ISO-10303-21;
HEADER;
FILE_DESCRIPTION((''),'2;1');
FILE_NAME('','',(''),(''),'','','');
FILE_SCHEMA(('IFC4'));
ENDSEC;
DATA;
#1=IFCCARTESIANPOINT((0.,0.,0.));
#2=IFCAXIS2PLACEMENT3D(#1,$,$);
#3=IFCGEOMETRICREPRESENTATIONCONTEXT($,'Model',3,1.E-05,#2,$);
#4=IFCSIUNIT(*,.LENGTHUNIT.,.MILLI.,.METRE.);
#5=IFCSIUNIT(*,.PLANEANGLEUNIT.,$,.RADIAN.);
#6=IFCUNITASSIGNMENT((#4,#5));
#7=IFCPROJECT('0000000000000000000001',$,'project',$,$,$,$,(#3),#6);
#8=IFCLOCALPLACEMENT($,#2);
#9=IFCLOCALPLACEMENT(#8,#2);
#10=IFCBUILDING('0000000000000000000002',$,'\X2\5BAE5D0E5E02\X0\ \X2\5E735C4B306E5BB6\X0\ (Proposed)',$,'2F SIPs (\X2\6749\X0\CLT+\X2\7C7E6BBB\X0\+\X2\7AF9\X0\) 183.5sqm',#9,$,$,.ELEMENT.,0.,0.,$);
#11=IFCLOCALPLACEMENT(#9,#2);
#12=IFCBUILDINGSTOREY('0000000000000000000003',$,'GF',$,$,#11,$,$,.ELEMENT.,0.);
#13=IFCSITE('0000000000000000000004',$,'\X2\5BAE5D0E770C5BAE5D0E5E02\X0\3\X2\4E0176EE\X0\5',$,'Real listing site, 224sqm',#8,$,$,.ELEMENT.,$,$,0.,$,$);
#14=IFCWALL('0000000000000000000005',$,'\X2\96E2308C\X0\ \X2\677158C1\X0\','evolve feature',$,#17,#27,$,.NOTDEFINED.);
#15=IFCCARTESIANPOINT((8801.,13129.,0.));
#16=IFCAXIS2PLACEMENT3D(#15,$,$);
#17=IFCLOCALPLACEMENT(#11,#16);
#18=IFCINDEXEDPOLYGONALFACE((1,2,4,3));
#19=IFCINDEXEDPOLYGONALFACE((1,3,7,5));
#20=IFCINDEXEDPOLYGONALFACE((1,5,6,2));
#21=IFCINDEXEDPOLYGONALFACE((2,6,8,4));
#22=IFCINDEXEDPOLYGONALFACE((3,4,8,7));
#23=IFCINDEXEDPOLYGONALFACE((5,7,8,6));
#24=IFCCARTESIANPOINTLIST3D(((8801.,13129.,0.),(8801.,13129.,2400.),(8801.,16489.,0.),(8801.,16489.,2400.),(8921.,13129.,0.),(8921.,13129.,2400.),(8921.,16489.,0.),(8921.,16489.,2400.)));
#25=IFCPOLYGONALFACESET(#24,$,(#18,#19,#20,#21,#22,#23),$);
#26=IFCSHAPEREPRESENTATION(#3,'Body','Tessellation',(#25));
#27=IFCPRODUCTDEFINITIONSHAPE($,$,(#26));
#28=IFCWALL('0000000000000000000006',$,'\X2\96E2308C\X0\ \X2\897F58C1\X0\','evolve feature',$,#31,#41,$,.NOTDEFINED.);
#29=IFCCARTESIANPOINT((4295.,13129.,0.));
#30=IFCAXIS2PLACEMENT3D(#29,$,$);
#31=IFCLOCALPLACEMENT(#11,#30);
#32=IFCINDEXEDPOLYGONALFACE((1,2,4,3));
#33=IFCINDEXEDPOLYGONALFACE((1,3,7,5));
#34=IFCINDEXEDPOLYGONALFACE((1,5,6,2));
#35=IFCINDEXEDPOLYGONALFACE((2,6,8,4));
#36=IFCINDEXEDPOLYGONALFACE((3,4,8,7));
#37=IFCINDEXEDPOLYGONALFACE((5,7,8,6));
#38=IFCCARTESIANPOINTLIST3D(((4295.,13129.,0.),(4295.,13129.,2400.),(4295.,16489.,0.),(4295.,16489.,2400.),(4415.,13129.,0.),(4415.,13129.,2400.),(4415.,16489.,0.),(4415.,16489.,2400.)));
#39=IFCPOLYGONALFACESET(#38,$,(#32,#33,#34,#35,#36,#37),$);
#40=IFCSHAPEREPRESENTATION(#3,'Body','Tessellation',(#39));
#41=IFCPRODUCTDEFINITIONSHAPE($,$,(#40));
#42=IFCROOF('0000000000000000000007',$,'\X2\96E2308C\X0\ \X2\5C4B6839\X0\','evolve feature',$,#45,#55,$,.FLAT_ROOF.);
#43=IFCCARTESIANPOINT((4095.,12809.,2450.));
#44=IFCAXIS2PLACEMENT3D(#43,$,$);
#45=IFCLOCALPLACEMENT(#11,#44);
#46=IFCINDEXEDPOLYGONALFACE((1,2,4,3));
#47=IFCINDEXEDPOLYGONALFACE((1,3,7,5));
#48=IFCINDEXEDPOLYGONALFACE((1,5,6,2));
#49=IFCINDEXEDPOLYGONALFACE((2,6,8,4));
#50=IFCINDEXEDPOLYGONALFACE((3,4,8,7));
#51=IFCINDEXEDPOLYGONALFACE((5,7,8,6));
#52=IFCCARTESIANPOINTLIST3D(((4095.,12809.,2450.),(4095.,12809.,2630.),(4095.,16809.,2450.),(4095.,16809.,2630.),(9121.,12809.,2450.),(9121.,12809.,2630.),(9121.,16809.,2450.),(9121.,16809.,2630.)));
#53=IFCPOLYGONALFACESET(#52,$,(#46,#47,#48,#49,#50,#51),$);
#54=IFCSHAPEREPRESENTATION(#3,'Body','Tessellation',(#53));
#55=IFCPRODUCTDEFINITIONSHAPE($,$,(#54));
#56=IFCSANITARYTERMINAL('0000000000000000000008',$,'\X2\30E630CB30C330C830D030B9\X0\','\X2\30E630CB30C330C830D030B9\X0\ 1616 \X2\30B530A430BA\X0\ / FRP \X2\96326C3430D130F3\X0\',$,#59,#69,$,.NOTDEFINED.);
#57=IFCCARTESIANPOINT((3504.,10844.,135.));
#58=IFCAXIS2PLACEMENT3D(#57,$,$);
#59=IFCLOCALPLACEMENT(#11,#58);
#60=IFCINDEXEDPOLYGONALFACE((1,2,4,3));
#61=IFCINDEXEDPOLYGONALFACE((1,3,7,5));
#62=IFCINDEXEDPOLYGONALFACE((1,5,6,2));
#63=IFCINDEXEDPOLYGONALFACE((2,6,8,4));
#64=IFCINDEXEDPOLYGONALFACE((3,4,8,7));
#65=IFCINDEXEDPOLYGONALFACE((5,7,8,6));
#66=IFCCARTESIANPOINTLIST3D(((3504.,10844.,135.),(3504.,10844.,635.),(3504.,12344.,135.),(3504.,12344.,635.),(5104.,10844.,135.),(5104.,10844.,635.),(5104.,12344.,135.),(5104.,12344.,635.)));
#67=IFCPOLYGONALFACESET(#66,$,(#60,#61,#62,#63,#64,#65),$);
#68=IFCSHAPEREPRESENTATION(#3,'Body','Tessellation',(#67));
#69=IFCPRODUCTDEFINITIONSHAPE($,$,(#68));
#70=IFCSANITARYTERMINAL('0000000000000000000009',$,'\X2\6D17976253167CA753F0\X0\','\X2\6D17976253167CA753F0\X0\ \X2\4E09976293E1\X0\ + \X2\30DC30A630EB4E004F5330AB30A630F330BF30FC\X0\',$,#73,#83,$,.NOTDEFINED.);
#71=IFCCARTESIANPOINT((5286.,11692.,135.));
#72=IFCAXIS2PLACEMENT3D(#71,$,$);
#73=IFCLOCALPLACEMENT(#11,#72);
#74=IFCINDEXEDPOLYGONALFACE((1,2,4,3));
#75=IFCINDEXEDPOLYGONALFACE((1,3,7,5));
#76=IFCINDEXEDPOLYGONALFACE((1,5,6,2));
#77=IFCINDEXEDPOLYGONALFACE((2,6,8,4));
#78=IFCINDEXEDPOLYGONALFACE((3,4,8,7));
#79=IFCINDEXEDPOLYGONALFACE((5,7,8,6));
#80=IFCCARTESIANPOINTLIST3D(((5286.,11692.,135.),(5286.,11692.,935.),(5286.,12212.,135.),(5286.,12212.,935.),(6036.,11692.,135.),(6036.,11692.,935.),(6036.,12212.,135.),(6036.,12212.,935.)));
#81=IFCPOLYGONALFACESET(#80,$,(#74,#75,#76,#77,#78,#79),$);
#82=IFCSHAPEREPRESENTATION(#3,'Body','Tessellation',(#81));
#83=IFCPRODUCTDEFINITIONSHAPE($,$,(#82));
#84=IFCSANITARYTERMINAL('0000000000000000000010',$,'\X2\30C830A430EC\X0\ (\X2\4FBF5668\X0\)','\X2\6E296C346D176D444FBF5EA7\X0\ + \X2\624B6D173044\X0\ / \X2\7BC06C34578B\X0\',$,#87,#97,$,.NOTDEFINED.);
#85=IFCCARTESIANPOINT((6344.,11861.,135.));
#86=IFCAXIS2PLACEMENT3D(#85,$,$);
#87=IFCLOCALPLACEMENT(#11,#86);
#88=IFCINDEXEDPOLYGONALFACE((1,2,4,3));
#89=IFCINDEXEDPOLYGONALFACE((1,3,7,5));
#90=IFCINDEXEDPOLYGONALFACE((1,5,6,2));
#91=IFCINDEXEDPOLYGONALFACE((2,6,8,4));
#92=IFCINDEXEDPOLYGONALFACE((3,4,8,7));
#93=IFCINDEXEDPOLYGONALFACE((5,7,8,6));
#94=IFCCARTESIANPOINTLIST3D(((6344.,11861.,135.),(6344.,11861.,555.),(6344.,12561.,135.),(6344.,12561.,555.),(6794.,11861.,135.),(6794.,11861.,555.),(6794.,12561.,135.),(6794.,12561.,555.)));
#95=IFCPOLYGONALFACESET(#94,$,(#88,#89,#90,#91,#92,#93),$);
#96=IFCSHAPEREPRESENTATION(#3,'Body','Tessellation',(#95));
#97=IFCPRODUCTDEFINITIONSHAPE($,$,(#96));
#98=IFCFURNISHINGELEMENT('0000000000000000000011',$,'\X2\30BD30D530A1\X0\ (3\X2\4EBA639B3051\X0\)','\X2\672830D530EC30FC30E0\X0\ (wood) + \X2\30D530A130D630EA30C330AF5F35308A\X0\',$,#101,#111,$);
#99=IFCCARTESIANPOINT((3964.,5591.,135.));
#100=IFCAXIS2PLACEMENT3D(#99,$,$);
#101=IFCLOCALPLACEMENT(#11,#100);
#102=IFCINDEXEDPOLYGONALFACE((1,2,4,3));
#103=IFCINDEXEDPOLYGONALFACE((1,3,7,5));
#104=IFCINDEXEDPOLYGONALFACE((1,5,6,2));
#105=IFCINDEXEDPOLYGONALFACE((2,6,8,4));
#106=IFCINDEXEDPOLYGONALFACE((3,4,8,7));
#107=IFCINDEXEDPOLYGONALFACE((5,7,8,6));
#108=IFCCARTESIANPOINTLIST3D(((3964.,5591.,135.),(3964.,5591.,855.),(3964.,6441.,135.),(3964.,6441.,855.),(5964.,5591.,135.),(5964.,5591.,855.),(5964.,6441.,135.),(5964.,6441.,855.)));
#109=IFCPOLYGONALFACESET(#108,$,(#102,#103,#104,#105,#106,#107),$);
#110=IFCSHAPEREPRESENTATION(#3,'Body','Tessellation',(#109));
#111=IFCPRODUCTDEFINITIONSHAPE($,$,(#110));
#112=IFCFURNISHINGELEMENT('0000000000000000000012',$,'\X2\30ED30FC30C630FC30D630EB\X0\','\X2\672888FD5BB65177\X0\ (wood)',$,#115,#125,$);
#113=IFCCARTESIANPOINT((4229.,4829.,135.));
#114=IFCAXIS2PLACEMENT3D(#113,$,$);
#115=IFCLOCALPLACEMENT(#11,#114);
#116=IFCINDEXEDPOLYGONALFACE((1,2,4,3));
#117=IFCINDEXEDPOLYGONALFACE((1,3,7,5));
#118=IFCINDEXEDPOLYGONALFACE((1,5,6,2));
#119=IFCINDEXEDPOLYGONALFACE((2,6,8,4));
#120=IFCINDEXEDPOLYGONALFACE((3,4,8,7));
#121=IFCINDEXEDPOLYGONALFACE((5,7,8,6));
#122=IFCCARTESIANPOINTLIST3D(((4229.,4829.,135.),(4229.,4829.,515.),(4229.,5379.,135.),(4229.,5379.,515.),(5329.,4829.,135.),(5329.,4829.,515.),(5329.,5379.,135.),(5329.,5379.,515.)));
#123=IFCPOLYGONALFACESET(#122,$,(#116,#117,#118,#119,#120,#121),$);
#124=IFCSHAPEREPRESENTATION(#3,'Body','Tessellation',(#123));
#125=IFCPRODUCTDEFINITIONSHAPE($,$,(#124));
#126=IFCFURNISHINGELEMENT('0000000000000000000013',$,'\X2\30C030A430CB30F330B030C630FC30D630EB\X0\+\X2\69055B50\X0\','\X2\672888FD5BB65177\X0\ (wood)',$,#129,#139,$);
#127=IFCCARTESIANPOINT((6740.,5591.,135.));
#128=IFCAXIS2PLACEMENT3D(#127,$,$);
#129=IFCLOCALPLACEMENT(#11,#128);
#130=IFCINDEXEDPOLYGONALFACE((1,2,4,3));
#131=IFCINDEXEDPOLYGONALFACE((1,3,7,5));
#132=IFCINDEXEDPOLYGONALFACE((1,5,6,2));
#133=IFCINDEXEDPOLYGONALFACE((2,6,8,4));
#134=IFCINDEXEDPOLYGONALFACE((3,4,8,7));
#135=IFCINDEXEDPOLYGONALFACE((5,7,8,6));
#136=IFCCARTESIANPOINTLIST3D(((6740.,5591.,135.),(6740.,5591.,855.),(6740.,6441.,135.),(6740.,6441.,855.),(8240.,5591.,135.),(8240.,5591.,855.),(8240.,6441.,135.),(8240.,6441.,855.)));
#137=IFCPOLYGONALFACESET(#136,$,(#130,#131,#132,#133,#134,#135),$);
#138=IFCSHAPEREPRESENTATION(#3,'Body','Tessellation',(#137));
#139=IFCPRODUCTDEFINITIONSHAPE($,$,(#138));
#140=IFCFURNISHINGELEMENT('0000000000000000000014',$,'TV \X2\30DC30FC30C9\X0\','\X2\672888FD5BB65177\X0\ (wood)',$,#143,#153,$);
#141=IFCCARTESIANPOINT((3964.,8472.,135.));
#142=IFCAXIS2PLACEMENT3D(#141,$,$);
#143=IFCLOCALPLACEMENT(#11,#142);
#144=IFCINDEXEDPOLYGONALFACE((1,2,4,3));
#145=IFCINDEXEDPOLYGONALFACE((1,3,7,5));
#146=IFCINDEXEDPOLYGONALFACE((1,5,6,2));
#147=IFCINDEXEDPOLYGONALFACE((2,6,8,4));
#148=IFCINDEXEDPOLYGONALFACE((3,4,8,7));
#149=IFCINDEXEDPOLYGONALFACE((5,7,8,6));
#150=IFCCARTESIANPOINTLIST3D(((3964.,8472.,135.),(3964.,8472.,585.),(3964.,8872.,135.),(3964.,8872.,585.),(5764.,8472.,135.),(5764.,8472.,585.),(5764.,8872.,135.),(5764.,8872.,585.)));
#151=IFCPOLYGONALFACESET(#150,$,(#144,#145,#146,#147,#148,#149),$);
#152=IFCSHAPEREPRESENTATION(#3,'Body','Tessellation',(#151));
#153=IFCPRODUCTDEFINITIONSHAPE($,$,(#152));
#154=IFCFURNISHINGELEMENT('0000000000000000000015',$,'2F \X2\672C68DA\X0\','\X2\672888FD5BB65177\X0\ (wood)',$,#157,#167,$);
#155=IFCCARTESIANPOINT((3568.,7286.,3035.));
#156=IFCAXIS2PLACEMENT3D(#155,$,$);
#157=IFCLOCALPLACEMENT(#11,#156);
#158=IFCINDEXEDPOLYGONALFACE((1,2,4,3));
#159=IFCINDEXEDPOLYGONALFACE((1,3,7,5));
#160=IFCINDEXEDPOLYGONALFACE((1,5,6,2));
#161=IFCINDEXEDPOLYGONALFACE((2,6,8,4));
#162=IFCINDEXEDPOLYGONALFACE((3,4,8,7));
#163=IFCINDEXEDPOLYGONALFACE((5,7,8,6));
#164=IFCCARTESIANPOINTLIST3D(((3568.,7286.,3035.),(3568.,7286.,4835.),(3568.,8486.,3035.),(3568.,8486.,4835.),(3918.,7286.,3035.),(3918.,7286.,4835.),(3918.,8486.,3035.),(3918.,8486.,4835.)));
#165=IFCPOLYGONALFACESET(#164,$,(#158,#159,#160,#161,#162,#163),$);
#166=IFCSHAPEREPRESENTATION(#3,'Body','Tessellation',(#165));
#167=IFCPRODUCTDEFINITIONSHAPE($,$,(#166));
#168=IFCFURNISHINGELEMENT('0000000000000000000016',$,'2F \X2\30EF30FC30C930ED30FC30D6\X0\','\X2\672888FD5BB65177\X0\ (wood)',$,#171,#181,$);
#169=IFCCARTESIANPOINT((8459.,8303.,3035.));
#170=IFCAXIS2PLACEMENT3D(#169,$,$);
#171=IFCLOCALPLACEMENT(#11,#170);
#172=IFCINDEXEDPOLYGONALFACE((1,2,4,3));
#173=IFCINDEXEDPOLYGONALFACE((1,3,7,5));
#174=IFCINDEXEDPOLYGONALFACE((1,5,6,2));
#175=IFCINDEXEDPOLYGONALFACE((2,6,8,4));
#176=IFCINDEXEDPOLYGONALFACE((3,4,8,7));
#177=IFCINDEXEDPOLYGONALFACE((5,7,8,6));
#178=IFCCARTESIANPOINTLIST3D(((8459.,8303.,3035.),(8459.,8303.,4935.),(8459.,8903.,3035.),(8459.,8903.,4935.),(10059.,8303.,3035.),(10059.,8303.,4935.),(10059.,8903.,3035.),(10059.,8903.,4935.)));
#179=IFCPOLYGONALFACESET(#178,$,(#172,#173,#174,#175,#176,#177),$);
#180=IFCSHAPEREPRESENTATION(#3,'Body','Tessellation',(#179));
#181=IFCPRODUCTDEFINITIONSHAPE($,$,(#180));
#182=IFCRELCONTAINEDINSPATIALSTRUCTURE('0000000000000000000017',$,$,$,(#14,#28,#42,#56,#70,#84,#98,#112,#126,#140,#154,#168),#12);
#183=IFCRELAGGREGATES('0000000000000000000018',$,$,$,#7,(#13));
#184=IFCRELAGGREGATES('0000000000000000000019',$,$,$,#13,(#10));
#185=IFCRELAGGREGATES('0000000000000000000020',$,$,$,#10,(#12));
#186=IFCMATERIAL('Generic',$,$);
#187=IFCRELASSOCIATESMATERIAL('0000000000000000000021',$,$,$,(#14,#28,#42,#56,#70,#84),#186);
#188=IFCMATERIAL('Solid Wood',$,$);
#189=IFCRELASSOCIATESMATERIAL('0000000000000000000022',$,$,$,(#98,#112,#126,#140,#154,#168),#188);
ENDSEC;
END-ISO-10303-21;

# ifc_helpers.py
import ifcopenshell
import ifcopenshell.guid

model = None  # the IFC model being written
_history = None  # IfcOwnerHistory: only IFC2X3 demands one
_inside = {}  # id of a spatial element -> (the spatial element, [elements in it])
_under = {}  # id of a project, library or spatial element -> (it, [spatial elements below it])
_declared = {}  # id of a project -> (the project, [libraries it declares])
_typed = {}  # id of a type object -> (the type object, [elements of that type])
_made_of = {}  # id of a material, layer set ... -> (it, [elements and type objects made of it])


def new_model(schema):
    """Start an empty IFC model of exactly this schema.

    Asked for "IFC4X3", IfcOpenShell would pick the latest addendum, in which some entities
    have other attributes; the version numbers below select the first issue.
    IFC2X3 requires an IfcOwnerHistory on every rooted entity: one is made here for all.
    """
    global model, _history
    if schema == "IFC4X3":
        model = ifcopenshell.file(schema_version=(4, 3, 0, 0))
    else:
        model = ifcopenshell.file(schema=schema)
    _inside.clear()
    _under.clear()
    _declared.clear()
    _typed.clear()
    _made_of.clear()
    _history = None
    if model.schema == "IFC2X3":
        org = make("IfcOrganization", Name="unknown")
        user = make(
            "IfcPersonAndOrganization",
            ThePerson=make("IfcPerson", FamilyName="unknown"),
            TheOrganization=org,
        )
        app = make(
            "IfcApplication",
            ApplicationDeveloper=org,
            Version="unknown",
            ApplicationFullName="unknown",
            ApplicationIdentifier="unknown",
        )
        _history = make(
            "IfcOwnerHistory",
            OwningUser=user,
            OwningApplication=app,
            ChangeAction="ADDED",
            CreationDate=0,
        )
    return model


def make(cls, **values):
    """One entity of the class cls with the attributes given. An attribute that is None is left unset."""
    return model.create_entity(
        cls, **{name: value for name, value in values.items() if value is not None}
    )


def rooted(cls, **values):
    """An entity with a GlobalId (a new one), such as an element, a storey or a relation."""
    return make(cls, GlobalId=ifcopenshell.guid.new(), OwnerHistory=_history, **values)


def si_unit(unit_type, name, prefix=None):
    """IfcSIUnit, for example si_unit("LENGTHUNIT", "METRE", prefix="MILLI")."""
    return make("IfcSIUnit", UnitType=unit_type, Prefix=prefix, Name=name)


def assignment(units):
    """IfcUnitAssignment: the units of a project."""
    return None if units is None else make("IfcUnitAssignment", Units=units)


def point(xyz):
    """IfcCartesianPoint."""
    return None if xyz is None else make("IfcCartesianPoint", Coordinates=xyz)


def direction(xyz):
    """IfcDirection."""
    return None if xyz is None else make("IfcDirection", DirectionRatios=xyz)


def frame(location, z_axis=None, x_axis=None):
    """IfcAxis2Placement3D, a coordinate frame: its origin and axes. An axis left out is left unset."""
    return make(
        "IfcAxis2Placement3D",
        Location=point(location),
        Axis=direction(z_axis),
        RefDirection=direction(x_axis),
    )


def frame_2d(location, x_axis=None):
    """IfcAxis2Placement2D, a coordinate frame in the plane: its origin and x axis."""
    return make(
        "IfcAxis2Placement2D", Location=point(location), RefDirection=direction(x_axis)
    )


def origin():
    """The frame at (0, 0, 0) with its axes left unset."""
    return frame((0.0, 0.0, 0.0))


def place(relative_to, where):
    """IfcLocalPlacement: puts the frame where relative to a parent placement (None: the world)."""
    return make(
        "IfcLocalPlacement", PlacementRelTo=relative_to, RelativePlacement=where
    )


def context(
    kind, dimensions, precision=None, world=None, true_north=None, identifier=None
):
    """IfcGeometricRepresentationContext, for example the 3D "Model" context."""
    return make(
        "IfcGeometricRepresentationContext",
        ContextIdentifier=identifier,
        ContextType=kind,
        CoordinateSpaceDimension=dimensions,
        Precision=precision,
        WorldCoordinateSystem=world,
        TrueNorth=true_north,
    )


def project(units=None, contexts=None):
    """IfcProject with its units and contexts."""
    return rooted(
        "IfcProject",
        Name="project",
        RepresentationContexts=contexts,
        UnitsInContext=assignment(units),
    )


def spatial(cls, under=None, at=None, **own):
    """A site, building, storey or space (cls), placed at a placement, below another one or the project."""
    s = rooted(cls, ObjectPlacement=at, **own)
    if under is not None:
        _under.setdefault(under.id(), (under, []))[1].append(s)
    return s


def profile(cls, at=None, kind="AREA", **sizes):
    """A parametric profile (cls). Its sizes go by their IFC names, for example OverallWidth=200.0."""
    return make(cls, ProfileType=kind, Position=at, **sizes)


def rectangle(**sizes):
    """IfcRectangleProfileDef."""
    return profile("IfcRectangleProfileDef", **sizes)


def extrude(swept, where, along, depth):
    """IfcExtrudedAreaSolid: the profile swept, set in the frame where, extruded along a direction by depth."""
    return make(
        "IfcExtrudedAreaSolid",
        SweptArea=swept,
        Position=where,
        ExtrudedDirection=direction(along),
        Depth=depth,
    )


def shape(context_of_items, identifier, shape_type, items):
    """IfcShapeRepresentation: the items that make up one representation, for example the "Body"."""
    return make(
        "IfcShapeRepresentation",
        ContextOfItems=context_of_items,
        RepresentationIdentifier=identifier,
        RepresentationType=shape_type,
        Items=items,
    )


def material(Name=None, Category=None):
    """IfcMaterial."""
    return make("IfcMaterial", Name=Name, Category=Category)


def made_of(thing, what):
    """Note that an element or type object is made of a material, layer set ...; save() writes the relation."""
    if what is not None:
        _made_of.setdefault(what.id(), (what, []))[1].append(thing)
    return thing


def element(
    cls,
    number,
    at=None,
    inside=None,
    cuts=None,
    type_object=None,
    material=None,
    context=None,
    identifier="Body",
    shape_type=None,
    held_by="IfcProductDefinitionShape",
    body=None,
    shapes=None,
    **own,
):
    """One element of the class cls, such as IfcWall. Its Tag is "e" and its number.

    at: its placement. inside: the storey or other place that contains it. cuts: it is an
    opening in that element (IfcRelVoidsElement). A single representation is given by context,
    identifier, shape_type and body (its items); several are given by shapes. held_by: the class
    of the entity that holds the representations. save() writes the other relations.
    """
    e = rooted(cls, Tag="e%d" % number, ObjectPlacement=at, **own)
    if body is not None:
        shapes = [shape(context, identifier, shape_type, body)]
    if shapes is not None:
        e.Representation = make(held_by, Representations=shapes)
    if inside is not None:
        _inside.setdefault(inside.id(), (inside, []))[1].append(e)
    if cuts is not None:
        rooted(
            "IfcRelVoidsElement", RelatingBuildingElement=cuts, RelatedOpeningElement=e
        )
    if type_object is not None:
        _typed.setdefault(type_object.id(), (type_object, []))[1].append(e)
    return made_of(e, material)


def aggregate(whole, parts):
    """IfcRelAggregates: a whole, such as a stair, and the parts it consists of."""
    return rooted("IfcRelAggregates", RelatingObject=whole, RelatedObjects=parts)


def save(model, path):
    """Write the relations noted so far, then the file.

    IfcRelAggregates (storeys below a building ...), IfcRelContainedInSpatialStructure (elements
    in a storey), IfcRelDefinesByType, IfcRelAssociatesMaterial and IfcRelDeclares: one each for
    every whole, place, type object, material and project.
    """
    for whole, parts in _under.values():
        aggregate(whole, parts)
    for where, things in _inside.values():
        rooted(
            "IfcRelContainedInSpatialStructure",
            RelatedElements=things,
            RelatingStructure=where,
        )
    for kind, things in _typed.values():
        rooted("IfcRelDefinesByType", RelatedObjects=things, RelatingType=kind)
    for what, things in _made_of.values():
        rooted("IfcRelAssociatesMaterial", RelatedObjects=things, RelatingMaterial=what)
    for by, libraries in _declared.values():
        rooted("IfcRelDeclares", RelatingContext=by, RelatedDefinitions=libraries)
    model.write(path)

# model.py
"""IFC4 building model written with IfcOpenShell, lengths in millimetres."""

from ifc_helpers import new_model, si_unit, frame, frame_2d, origin, place, context, project, spatial, rectangle, extrude, material, element, save


model = new_model("IFC4")

# Units and contexts
model_context = context("Model", 3, precision=1e-05, world=origin())
ifc_project = project(units=[si_unit("LENGTHUNIT", "METRE", prefix="MILLI"), si_unit("PLANEANGLEUNIT", "RADIAN")], contexts=[model_context])

# Site, building, storey
site_placement = place(None, origin())
site = spatial("IfcSite", under=ifc_project, at=site_placement, Name="宮崎県宮崎市3丁目5", ObjectType="Real listing site, 224sqm", CompositionType="ELEMENT", RefElevation=0.0)
building_placement = place(site_placement, origin())
building = spatial("IfcBuilding", under=site, at=building_placement, Name="宮崎市 平屋の家 (Proposed)", ObjectType="2F SIPs (杉CLT+籾殻+竹) 183.5sqm", CompositionType="ELEMENT", ElevationOfRefHeight=0.0, ElevationOfTerrain=0.0)
storey_placement = place(building_placement, origin())
storey = spatial("IfcBuildingStorey", under=building, at=storey_placement, Name="GF", CompositionType="ELEMENT", Elevation=0.0)

# Shared definitions
ifc_material_1 = material(Name="Generic")

# Shared definitions
ifc_material_2 = material(Name="Solid Wood")

# Walls
wall_1_placement = place(storey_placement, frame((8801.0, 13129.0, 0.0)))
element("IfcWall", 1, at=wall_1_placement, inside=storey, material=ifc_material_1, Name="離れ 東壁", Description="evolve feature", PredefinedType="NOTDEFINED", context=model_context, shape_type="SweptSolid", body=[
    extrude(rectangle(XDim=120.0, YDim=3360.0, at=frame_2d((60.0, 1680.0))), frame((8801.0, 13129.0, 0.0)), (0.0, 0.0, 1.0), 2400.0),
])
wall_2_placement = place(storey_placement, frame((4295.0, 13129.0, 0.0)))
element("IfcWall", 2, at=wall_2_placement, inside=storey, material=ifc_material_1, Name="離れ 西壁", Description="evolve feature", PredefinedType="NOTDEFINED", context=model_context, shape_type="SweptSolid", body=[
    extrude(rectangle(XDim=120.0, YDim=3360.0, at=frame_2d((60.0, 1680.0))), frame((4295.0, 13129.0, 0.0)), (0.0, 0.0, 1.0), 2400.0),
])

# Roof
roof_1_placement = place(storey_placement, frame((4095.0, 12809.0, 2450.0)))
element("IfcRoof", 3, at=roof_1_placement, inside=storey, material=ifc_material_1, Name="離れ 屋根", Description="evolve feature", PredefinedType="FLAT_ROOF", context=model_context, shape_type="SweptSolid", body=[
    extrude(rectangle(XDim=5026.0, YDim=4000.0, at=frame_2d((2513.0, 2000.0))), frame((4095.0, 12809.0, 2450.0)), (0.0, 0.0, 1.0), 180.0),
])

# Sanitary terminals
sanitary_terminal_1_placement = place(storey_placement, frame((3504.0, 10844.0, 135.0)))
element("IfcSanitaryTerminal", 4, at=sanitary_terminal_1_placement, inside=storey, material=ifc_material_1, Name="ユニットバス", Description="ユニットバス 1616 サイズ / FRP 防水パン", PredefinedType="NOTDEFINED", context=model_context, shape_type="SweptSolid", body=[
    extrude(rectangle(XDim=1600.0, YDim=1500.0, at=frame_2d((800.0, 750.0))), frame((3504.0, 10844.0, 135.0)), (0.0, 0.0, 1.0), 500.0),
])
sanitary_terminal_2_placement = place(storey_placement, frame((5286.0, 11692.0, 135.0)))
element("IfcSanitaryTerminal", 5, at=sanitary_terminal_2_placement, inside=storey, material=ifc_material_1, Name="洗面化粧台", Description="洗面化粧台 三面鏡 + ボウル一体カウンター", PredefinedType="NOTDEFINED", context=model_context, shape_type="SweptSolid", body=[
    extrude(rectangle(XDim=750.0, YDim=520.0, at=frame_2d((375.0, 260.0))), frame((5286.0, 11692.0, 135.0)), (0.0, 0.0, 1.0), 800.0),
])
sanitary_terminal_3_placement = place(storey_placement, frame((6344.0, 11861.0, 135.0)))
element("IfcSanitaryTerminal", 6, at=sanitary_terminal_3_placement, inside=storey, material=ifc_material_1, Name="トイレ (便器)", Description="温水洗浄便座 + 手洗い / 節水型", PredefinedType="NOTDEFINED", context=model_context, shape_type="SweptSolid", body=[
    extrude(rectangle(XDim=450.0, YDim=700.0, at=frame_2d((225.0, 350.0))), frame((6344.0, 11861.0, 135.0)), (0.0, 0.0, 1.0), 420.0),
])

# Furnishing elements
furnishing_1_placement = place(storey_placement, frame((3964.0, 5591.0, 135.0)))
element("IfcFurnishingElement", 7, at=furnishing_1_placement, inside=storey, material=ifc_material_2, Name="ソファ (3人掛け)", Description="木フレーム (wood) + ファブリック張り", context=model_context, shape_type="SweptSolid", body=[
    extrude(rectangle(XDim=2000.0, YDim=850.0, at=frame_2d((1000.0, 425.0))), frame((3964.0, 5591.0, 135.0)), (0.0, 0.0, 1.0), 720.0),
])
furnishing_2_placement = place(storey_placement, frame((4229.0, 4829.0, 135.0)))
element("IfcFurnishingElement", 8, at=furnishing_2_placement, inside=storey, material=ifc_material_2, Name="ローテーブル", Description="木製家具 (wood)", context=model_context, shape_type="SweptSolid", body=[
    extrude(rectangle(XDim=1100.0, YDim=550.0, at=frame_2d((550.0, 275.0))), frame((4229.0, 4829.0, 135.0)), (0.0, 0.0, 1.0), 380.0),
])
furnishing_3_placement = place(storey_placement, frame((6740.0, 5591.0, 135.0)))
element("IfcFurnishingElement", 9, at=furnishing_3_placement, inside=storey, material=ifc_material_2, Name="ダイニングテーブル+椅子", Description="木製家具 (wood)", context=model_context, shape_type="SweptSolid", body=[
    extrude(rectangle(XDim=1500.0, YDim=850.0, at=frame_2d((750.0, 425.0))), frame((6740.0, 5591.0, 135.0)), (0.0, 0.0, 1.0), 720.0),
])
furnishing_4_placement = place(storey_placement, frame((3964.0, 8472.0, 135.0)))
element("IfcFurnishingElement", 10, at=furnishing_4_placement, inside=storey, material=ifc_material_2, Name="TV ボード", Description="木製家具 (wood)", context=model_context, shape_type="SweptSolid", body=[
    extrude(rectangle(XDim=1800.0, YDim=400.0, at=frame_2d((900.0, 200.0))), frame((3964.0, 8472.0, 135.0)), (0.0, 0.0, 1.0), 450.0),
])
furnishing_5_placement = place(storey_placement, frame((3568.0, 7286.0, 3035.0)))
element("IfcFurnishingElement", 11, at=furnishing_5_placement, inside=storey, material=ifc_material_2, Name="2F 本棚", Description="木製家具 (wood)", context=model_context, shape_type="SweptSolid", body=[
    extrude(rectangle(XDim=350.0, YDim=1200.0, at=frame_2d((175.0, 600.0))), frame((3568.0, 7286.0, 3035.0)), (0.0, 0.0, 1.0), 1800.0),
])
furnishing_6_placement = place(storey_placement, frame((8459.0, 8303.0, 3035.0)))
element("IfcFurnishingElement", 12, at=furnishing_6_placement, inside=storey, material=ifc_material_2, Name="2F ワードローブ", Description="木製家具 (wood)", context=model_context, shape_type="SweptSolid", body=[
    extrude(rectangle(XDim=1600.0, YDim=600.0, at=frame_2d((800.0, 300.0))), frame((8459.0, 8303.0, 3035.0)), (0.0, 0.0, 1.0), 1900.0),
])

save(model, "model.ifc")
